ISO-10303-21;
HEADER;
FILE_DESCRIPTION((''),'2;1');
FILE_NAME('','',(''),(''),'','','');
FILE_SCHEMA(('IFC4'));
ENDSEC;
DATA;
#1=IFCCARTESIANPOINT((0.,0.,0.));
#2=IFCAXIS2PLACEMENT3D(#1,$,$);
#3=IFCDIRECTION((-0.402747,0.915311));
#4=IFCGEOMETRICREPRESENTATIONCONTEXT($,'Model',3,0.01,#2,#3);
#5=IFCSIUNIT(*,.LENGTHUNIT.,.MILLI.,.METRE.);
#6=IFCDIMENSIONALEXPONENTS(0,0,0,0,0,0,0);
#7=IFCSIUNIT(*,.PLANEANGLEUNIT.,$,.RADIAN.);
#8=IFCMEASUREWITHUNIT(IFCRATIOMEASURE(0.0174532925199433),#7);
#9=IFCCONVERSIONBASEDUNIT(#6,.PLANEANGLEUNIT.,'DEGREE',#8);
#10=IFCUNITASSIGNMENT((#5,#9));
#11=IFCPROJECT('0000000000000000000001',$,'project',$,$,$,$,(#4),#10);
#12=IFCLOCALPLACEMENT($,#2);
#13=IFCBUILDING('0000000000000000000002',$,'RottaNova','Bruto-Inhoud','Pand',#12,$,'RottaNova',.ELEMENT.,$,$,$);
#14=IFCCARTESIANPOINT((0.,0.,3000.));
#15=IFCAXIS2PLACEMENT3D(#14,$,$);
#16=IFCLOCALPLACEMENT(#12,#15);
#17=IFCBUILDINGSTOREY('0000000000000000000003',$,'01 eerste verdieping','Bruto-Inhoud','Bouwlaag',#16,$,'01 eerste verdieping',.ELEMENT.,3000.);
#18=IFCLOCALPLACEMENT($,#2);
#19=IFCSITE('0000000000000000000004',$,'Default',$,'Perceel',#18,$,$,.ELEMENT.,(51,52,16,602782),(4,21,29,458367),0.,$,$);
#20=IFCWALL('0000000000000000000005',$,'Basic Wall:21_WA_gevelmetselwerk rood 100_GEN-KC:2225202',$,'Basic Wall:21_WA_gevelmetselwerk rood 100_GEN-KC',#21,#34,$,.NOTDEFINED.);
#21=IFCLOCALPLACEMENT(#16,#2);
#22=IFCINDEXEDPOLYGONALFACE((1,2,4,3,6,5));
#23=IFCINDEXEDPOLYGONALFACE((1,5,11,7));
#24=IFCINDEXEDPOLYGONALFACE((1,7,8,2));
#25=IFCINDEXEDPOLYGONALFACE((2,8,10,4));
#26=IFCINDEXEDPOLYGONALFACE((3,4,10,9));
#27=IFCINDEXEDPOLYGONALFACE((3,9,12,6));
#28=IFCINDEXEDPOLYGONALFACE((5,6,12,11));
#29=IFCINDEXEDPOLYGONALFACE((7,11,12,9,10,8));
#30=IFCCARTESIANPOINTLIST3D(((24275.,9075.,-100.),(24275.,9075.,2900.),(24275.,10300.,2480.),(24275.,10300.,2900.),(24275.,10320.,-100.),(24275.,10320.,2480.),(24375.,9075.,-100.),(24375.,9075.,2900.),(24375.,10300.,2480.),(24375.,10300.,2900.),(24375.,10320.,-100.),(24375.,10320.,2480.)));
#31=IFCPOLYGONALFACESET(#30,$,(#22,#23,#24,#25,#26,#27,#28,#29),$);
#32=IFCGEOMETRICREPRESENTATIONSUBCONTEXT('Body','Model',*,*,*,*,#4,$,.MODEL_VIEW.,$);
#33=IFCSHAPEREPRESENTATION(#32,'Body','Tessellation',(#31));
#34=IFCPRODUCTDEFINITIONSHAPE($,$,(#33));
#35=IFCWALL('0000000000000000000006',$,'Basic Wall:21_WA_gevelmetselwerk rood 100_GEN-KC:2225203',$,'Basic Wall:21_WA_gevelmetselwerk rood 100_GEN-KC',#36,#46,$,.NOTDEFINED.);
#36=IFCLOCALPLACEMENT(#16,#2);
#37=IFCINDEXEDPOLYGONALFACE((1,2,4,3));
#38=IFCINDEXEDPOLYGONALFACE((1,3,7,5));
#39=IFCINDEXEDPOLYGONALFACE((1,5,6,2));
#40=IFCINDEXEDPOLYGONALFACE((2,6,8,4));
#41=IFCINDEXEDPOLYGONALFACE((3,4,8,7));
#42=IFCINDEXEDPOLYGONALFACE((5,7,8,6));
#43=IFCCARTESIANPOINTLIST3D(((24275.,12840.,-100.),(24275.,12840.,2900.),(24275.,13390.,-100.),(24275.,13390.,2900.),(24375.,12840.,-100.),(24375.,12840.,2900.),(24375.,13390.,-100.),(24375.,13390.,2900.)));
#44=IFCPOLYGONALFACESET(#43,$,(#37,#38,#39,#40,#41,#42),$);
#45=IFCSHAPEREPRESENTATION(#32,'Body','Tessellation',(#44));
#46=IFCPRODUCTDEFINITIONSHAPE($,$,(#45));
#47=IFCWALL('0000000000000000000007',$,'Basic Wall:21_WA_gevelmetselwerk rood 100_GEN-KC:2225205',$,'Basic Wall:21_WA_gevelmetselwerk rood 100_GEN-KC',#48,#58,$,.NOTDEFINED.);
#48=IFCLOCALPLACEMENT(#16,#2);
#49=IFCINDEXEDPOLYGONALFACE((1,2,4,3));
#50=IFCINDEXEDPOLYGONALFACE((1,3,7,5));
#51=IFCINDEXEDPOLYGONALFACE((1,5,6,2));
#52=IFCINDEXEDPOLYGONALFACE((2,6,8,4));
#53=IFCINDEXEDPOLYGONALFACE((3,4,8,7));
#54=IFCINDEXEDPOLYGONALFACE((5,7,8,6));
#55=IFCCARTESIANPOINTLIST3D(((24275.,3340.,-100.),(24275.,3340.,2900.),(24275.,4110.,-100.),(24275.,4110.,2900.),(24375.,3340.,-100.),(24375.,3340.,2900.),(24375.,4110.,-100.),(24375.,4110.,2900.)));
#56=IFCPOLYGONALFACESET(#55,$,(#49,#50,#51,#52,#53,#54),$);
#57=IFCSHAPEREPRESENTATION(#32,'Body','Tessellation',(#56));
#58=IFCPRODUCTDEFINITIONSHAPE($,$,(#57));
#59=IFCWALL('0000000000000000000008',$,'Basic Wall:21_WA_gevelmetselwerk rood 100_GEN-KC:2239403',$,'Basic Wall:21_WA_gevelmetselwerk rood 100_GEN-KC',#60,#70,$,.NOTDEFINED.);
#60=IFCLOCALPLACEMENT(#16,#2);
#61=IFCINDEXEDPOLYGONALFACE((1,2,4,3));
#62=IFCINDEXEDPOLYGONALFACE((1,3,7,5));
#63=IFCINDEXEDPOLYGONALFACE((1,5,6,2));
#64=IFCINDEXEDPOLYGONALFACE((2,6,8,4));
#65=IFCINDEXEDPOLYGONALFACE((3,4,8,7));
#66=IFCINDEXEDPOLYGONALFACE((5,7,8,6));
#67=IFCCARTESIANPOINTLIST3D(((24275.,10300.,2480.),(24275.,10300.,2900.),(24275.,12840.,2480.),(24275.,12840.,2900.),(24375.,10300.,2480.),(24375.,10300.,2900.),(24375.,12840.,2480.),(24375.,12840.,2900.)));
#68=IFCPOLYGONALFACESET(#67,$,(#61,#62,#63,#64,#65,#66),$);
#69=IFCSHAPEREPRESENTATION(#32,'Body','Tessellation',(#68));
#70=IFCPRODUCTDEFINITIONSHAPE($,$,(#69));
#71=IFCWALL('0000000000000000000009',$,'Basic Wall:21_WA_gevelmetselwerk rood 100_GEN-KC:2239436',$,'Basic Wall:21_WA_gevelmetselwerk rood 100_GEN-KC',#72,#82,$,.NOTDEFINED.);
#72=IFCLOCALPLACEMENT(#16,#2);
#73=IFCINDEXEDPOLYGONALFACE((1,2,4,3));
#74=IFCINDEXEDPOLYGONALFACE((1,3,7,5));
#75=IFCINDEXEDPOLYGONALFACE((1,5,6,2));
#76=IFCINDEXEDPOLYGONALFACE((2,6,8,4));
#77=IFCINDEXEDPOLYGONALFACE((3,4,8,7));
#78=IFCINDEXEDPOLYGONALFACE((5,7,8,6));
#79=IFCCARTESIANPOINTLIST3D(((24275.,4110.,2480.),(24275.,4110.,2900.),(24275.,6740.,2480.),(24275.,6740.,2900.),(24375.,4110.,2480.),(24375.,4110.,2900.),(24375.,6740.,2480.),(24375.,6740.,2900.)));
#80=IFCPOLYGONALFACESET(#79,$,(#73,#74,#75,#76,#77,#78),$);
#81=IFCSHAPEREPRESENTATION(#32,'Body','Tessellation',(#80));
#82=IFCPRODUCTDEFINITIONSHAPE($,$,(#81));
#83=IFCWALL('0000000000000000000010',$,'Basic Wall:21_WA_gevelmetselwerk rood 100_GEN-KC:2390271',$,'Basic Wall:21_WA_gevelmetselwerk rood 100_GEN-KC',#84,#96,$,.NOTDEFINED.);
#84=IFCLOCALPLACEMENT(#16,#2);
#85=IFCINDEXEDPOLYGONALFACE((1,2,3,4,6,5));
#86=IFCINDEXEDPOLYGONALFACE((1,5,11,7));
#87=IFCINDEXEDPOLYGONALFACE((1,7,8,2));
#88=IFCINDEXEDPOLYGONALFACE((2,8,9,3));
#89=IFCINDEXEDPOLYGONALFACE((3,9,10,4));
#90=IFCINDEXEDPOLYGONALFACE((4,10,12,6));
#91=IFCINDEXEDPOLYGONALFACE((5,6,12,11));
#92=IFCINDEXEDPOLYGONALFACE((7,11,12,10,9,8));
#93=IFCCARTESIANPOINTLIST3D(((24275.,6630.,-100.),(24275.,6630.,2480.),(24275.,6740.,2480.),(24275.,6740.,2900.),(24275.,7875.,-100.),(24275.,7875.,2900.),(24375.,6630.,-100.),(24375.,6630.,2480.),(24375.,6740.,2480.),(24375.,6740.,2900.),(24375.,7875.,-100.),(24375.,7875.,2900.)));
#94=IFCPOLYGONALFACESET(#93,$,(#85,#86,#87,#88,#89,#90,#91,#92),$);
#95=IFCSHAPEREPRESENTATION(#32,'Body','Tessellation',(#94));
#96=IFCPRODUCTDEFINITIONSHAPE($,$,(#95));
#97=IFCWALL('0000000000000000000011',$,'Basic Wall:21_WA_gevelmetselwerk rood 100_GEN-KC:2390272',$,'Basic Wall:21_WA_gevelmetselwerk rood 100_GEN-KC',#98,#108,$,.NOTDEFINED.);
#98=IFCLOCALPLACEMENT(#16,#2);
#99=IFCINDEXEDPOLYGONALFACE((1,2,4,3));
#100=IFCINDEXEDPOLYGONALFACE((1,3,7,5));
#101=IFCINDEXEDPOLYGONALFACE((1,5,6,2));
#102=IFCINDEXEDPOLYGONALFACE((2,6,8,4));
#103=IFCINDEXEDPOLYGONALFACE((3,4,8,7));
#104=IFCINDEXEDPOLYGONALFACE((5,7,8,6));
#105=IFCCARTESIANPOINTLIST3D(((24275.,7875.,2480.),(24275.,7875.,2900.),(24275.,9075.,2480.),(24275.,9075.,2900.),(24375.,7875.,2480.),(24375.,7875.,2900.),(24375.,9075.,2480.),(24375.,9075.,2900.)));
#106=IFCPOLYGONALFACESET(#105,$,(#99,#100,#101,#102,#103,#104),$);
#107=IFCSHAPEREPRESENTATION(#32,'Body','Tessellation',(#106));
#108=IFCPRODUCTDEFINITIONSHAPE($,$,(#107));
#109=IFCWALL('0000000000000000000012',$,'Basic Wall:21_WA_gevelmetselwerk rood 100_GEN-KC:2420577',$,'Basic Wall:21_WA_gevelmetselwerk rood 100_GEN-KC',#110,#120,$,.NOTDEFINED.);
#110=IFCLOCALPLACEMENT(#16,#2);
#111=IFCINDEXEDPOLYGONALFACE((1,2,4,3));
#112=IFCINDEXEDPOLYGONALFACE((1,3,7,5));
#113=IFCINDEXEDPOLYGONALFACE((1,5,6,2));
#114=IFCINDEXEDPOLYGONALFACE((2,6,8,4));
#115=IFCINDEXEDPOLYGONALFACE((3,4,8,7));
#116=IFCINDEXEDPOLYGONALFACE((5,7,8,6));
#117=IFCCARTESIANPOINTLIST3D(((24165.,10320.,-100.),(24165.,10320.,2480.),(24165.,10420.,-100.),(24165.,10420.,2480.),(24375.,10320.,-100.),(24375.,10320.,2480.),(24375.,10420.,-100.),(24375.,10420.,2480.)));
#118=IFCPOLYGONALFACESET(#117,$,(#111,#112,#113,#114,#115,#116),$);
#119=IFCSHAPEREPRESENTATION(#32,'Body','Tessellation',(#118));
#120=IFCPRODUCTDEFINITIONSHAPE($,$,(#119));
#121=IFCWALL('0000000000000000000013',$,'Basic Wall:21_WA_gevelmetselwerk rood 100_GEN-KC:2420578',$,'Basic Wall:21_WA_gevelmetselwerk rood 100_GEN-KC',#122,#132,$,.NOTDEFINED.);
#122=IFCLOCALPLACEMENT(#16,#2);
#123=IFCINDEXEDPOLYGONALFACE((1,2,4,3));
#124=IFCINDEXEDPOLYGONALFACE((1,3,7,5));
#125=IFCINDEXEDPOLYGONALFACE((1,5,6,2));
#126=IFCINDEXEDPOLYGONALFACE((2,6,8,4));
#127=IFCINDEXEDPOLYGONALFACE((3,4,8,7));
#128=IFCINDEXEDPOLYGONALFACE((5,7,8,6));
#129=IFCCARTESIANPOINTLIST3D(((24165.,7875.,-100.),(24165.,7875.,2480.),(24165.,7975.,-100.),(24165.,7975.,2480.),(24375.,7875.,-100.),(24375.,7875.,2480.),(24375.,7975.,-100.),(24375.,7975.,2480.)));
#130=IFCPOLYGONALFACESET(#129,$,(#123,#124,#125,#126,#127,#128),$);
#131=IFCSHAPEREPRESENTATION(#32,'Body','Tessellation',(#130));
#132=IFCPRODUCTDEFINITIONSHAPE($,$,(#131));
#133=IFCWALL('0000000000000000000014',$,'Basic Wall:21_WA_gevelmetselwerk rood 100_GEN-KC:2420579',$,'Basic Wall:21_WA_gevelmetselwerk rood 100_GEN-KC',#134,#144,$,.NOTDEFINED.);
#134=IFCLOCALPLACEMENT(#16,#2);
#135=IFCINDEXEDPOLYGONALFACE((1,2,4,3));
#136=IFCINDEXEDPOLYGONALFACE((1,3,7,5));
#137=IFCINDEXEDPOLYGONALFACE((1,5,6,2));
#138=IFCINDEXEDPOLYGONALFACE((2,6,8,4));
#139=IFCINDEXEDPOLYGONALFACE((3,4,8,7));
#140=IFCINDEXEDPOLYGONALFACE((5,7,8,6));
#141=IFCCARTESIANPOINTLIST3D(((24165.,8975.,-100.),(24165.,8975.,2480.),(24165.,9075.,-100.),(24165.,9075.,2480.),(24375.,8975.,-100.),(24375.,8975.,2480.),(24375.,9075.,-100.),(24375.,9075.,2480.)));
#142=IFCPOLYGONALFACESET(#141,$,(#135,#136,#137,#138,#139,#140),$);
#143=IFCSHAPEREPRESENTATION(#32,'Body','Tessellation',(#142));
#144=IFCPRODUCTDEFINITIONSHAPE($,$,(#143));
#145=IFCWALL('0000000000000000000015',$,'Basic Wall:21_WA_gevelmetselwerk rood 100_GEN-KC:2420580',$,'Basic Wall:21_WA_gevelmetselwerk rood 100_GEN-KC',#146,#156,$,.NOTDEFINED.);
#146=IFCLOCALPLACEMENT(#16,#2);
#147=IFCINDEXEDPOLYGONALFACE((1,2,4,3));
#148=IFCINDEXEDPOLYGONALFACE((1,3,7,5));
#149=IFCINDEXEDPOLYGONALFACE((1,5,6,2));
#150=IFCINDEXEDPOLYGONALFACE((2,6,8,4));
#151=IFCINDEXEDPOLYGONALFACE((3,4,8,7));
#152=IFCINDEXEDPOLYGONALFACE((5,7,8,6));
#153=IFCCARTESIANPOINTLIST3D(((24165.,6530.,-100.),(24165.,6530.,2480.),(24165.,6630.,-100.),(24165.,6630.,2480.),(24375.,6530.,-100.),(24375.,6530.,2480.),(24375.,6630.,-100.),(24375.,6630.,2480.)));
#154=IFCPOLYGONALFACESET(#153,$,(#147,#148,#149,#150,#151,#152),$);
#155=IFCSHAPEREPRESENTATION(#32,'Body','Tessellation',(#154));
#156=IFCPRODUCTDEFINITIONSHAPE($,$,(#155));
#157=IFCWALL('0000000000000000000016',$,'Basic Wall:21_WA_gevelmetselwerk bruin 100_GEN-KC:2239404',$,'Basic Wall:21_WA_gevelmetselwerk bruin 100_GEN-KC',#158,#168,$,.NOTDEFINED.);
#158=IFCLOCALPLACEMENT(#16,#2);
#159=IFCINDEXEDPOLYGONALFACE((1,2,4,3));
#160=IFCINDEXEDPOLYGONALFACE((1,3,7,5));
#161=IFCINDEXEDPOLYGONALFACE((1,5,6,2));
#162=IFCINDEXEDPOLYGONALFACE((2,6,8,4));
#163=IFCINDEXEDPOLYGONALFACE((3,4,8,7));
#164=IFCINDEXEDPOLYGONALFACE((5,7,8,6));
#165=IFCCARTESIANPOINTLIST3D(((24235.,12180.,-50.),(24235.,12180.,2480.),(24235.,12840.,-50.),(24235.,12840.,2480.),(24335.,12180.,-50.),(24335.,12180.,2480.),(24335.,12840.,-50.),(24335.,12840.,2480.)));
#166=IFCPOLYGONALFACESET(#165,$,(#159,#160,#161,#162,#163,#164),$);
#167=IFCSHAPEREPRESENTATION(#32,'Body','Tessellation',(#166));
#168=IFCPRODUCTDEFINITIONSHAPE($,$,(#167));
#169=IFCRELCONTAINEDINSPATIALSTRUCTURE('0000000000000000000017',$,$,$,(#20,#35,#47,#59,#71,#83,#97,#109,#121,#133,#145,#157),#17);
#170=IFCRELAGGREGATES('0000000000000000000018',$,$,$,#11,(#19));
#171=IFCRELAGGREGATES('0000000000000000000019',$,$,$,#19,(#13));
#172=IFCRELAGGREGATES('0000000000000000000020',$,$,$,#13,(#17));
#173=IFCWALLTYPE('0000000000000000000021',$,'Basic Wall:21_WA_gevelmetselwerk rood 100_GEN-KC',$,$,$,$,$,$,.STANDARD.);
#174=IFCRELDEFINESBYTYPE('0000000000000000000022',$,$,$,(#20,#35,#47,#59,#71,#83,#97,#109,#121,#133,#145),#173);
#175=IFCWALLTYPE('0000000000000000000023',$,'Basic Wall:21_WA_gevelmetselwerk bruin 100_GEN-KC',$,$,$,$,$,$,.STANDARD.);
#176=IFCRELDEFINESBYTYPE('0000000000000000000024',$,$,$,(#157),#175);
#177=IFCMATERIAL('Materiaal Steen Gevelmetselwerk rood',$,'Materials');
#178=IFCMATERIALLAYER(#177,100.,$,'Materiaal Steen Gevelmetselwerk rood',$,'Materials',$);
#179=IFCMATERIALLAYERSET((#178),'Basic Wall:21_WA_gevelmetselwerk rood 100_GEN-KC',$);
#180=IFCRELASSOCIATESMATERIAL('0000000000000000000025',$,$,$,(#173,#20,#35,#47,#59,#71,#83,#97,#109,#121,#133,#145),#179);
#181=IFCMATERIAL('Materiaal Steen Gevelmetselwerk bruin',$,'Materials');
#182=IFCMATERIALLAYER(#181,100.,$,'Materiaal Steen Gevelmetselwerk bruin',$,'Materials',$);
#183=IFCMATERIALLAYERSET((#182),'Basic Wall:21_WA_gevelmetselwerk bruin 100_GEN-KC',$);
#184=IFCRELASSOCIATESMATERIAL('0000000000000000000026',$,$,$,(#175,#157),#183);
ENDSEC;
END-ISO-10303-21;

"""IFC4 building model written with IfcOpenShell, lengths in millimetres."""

from ifc_helpers import new_model, entity, si_unit, converted_unit, direction, frame, frame_2d, origin, place, context, subcontext, project, spatial, polyline, rectangle, extrude, clip, bounded_halfspace, material, layer, layer_set, type_object, element, save


model = new_model("IFC4")

# Units and contexts
model_context = context("Model", 3, precision=0.01, world=origin(), true_north=direction((-0.402747, 0.915311)))
body_context = subcontext(model_context, "Body", "Model", "MODEL_VIEW")
ifc_project = project(units=[si_unit("LENGTHUNIT", "METRE", prefix="MILLI"), converted_unit("PLANEANGLEUNIT", "DEGREE", entity("IfcRatioMeasure", 0.0174532925199433), si_unit("PLANEANGLEUNIT", "RADIAN"), dimensions=[0, 0, 0, 0, 0, 0, 0])], contexts=[model_context])

# Site, building, storey
site_placement = place(None, origin())
site = spatial("IfcSite", under=ifc_project, at=site_placement, Name="Default", ObjectType="Perceel", CompositionType="ELEMENT", RefLatitude=(51, 52, 16, 602782), RefLongitude=(4, 21, 29, 458367), RefElevation=0.0)
building_placement = place(None, origin())
building = spatial("IfcBuilding", under=site, at=building_placement, Name="RottaNova", Description="Bruto-Inhoud", ObjectType="Pand", LongName="RottaNova", CompositionType="ELEMENT")
storey_placement = place(building_placement, frame((0.0, 0.0, 3000.0)))
storey = spatial("IfcBuildingStorey", under=building, at=storey_placement, Name="01 eerste verdieping", Description="Bruto-Inhoud", ObjectType="Bouwlaag", LongName="01 eerste verdieping", CompositionType="ELEMENT", Elevation=3000.0)

# Walls
ifc_material_1 = material(Name="Materiaal Steen Gevelmetselwerk rood", Category="Materials")
ifc_layer_1 = layer(ifc_material_1, 100.0, Name="Materiaal Steen Gevelmetselwerk rood", Category="Materials")
ifc_layer_set_1 = layer_set([ifc_layer_1], Name="Basic Wall:21_WA_gevelmetselwerk rood 100_GEN-KC")
wall_type_1 = type_object("IfcWallType", Name="Basic Wall:21_WA_gevelmetselwerk rood 100_GEN-KC", PredefinedType="STANDARD", material=ifc_layer_set_1)
wall_1_placement = place(storey_placement, frame((24325.0, 9075.0, -100.0), z_axis=(0.0, 0.0, 1.0), x_axis=(0.0, 1.0, 0.0)))
element("IfcWall", 1, at=wall_1_placement, inside=storey, type_object=wall_type_1, material=ifc_layer_set_1, Name="Basic Wall:21_WA_gevelmetselwerk rood 100_GEN-KC:2225202", ObjectType="Basic Wall:21_WA_gevelmetselwerk rood 100_GEN-KC", PredefinedType="NOTDEFINED", context=body_context, shape_type="Clipping", body=[
    clip(clip(extrude(rectangle(XDim=1245.0, YDim=100.0, at=frame_2d((622.5, 0.0), x_axis=(-1.0, 0.0))), origin(), (0.0, 0.0, 1.0), 3000.0), bounded_halfspace(frame((1225.0, 50.0, 2580.0), z_axis=(0.0, 0.0, -1.0), x_axis=(0.0, -1.0, 0.0)), True, frame((1225.0, 50.0, 2580.0), z_axis=(0.0, 0.0, -1.0), x_axis=(0.0, -1.0, 0.0)), polyline([(0.0, 0.0), (0.0, -20.0), (100.0, -20.0), (100.0, 0.0), (0.0, 0.0)]))), bounded_halfspace(frame((1225.0, -50.0, 2580.0), z_axis=(-1.0, 0.0, 0.0), x_axis=(0.0, -1.0, 0.0)), True, frame((1225.0, -50.0, 2580.0), z_axis=(-1.0, 0.0, 0.0), x_axis=(0.0, -1.0, 0.0)), polyline([(0.0, 0.0), (0.0, 128016.0), (-30480.0, 128016.0), (-30480.0, 0.0), (0.0, 0.0)]))),
])
wall_2_placement = place(storey_placement, frame((24325.0, 12840.0, -100.0), z_axis=(0.0, 0.0, 1.0), x_axis=(0.0, 1.0, 0.0)))
element("IfcWall", 2, at=wall_2_placement, inside=storey, type_object=wall_type_1, material=ifc_layer_set_1, Name="Basic Wall:21_WA_gevelmetselwerk rood 100_GEN-KC:2225203", ObjectType="Basic Wall:21_WA_gevelmetselwerk rood 100_GEN-KC", PredefinedType="NOTDEFINED", context=body_context, shape_type="SweptSolid", body=[
    extrude(rectangle(XDim=550.0, YDim=100.0, at=frame_2d((275.0, 0.0), x_axis=(-1.0, 0.0))), origin(), (0.0, 0.0, 1.0), 3000.0),
])
wall_3_placement = place(storey_placement, frame((24325.0, 3340.0, -100.0), z_axis=(0.0, 0.0, 1.0), x_axis=(0.0, 1.0, 0.0)))
element("IfcWall", 3, at=wall_3_placement, inside=storey, type_object=wall_type_1, material=ifc_layer_set_1, Name="Basic Wall:21_WA_gevelmetselwerk rood 100_GEN-KC:2225205", ObjectType="Basic Wall:21_WA_gevelmetselwerk rood 100_GEN-KC", PredefinedType="NOTDEFINED", context=body_context, shape_type="SweptSolid", body=[
    extrude(rectangle(XDim=770.0, YDim=100.0, at=frame_2d((385.0, 0.0), x_axis=(-1.0, 0.0))), origin(), (0.0, 0.0, 1.0), 3000.0),
])
wall_4_placement = place(storey_placement, frame((24325.0, 12840.0, 2480.0), z_axis=(0.0, 0.0, 1.0), x_axis=(0.0, -1.0, 0.0)))
element("IfcWall", 4, at=wall_4_placement, inside=storey, type_object=wall_type_1, material=ifc_layer_set_1, Name="Basic Wall:21_WA_gevelmetselwerk rood 100_GEN-KC:2239403", ObjectType="Basic Wall:21_WA_gevelmetselwerk rood 100_GEN-KC", PredefinedType="NOTDEFINED", context=body_context, shape_type="SweptSolid", body=[
    extrude(rectangle(XDim=2540.0, YDim=100.0, at=frame_2d((1270.0, 0.0), x_axis=(-1.0, 0.0))), origin(), (0.0, 0.0, 1.0), 420.0),
])
wall_5_placement = place(storey_placement, frame((24325.0, 4110.0, 2480.0), z_axis=(0.0, 0.0, 1.0), x_axis=(0.0, 1.0, 0.0)))
element("IfcWall", 5, at=wall_5_placement, inside=storey, type_object=wall_type_1, material=ifc_layer_set_1, Name="Basic Wall:21_WA_gevelmetselwerk rood 100_GEN-KC:2239436", ObjectType="Basic Wall:21_WA_gevelmetselwerk rood 100_GEN-KC", PredefinedType="NOTDEFINED", context=body_context, shape_type="SweptSolid", body=[
    extrude(rectangle(XDim=2630.0, YDim=100.0, at=frame_2d((1315.0, 0.0), x_axis=(-1.0, 0.0))), origin(), (0.0, 0.0, 1.0), 420.0),
])
wall_6_placement = place(storey_placement, frame((24325.0, 6630.0, -100.0), z_axis=(0.0, 0.0, 1.0), x_axis=(0.0, 1.0, 0.0)))
element("IfcWall", 6, at=wall_6_placement, inside=storey, type_object=wall_type_1, material=ifc_layer_set_1, Name="Basic Wall:21_WA_gevelmetselwerk rood 100_GEN-KC:2390271", ObjectType="Basic Wall:21_WA_gevelmetselwerk rood 100_GEN-KC", PredefinedType="NOTDEFINED", context=body_context, shape_type="Clipping", body=[
    clip(clip(extrude(rectangle(XDim=1245.0, YDim=100.0, at=frame_2d((622.5, 0.0), x_axis=(-1.0, 0.0))), origin(), (0.0, 0.0, 1.0), 3000.0), bounded_halfspace(frame((110.0, -50.0, 2580.0), z_axis=(0.0, 0.0, -1.0), x_axis=(0.0, 1.0, 0.0)), True, frame((110.0, -50.0, 2580.0), z_axis=(0.0, 0.0, -1.0), x_axis=(0.0, 1.0, 0.0)), polyline([(0.0, 0.0), (0.0, -110.0), (100.0, -110.0), (100.0, 0.0), (0.0, 0.0)]))), bounded_halfspace(frame((110.0, 50.0, 2580.0), z_axis=(1.0, 0.0, 0.0), x_axis=(0.0, 1.0, 0.0)), True, frame((110.0, 50.0, 2580.0), z_axis=(1.0, 0.0, 0.0), x_axis=(0.0, 1.0, 0.0)), polyline([(0.0, 0.0), (0.0, 128016.0), (-30480.0, 128016.0), (-30480.0, 0.0), (0.0, 0.0)]))),
])
wall_7_placement = place(storey_placement, frame((24325.0, 7875.0, 2480.0), z_axis=(0.0, 0.0, 1.0), x_axis=(0.0, 1.0, 0.0)))
element("IfcWall", 7, at=wall_7_placement, inside=storey, type_object=wall_type_1, material=ifc_layer_set_1, Name="Basic Wall:21_WA_gevelmetselwerk rood 100_GEN-KC:2390272", ObjectType="Basic Wall:21_WA_gevelmetselwerk rood 100_GEN-KC", PredefinedType="NOTDEFINED", context=body_context, shape_type="SweptSolid", body=[
    extrude(rectangle(XDim=1200.0, YDim=100.0, at=frame_2d((600.0, 0.0), x_axis=(-1.0, 0.0))), origin(), (0.0, 0.0, 1.0), 420.0),
])
wall_8_placement = place(storey_placement, frame((24375.0, 10370.0, -100.0), z_axis=(0.0, 0.0, 1.0), x_axis=(-1.0, 0.0, 0.0)))
element("IfcWall", 8, at=wall_8_placement, inside=storey, type_object=wall_type_1, material=ifc_layer_set_1, Name="Basic Wall:21_WA_gevelmetselwerk rood 100_GEN-KC:2420577", ObjectType="Basic Wall:21_WA_gevelmetselwerk rood 100_GEN-KC", PredefinedType="NOTDEFINED", context=body_context, shape_type="SweptSolid", body=[
    extrude(rectangle(XDim=210.0, YDim=100.0, at=frame_2d((105.0, 0.0), x_axis=(-1.0, 0.0))), origin(), (0.0, 0.0, 1.0), 2580.0),
])
wall_9_placement = place(storey_placement, frame((24375.0, 7925.0, -100.0), z_axis=(0.0, 0.0, 1.0), x_axis=(-1.0, 0.0, 0.0)))
element("IfcWall", 9, at=wall_9_placement, inside=storey, type_object=wall_type_1, material=ifc_layer_set_1, Name="Basic Wall:21_WA_gevelmetselwerk rood 100_GEN-KC:2420578", ObjectType="Basic Wall:21_WA_gevelmetselwerk rood 100_GEN-KC", PredefinedType="NOTDEFINED", context=body_context, shape_type="SweptSolid", body=[
    extrude(rectangle(XDim=210.0, YDim=100.0, at=frame_2d((105.0, 0.0), x_axis=(-1.0, 0.0))), origin(), (0.0, 0.0, 1.0), 2580.0),
])
wall_10_placement = place(storey_placement, frame((24375.0, 9025.0, -100.0), z_axis=(0.0, 0.0, 1.0), x_axis=(-1.0, 0.0, 0.0)))
element("IfcWall", 10, at=wall_10_placement, inside=storey, type_object=wall_type_1, material=ifc_layer_set_1, Name="Basic Wall:21_WA_gevelmetselwerk rood 100_GEN-KC:2420579", ObjectType="Basic Wall:21_WA_gevelmetselwerk rood 100_GEN-KC", PredefinedType="NOTDEFINED", context=body_context, shape_type="SweptSolid", body=[
    extrude(rectangle(XDim=210.0, YDim=100.0, at=frame_2d((105.0, 0.0), x_axis=(-1.0, 0.0))), origin(), (0.0, 0.0, 1.0), 2580.0),
])
wall_11_placement = place(storey_placement, frame((24375.0, 6580.0, -100.0), z_axis=(0.0, 0.0, 1.0), x_axis=(-1.0, 0.0, 0.0)))
element("IfcWall", 11, at=wall_11_placement, inside=storey, type_object=wall_type_1, material=ifc_layer_set_1, Name="Basic Wall:21_WA_gevelmetselwerk rood 100_GEN-KC:2420580", ObjectType="Basic Wall:21_WA_gevelmetselwerk rood 100_GEN-KC", PredefinedType="NOTDEFINED", context=body_context, shape_type="SweptSolid", body=[
    extrude(rectangle(XDim=210.0, YDim=100.0, at=frame_2d((105.0, 0.0), x_axis=(-1.0, 0.0))), origin(), (0.0, 0.0, 1.0), 2580.0),
])
ifc_material_2 = material(Name="Materiaal Steen Gevelmetselwerk bruin", Category="Materials")
ifc_layer_2 = layer(ifc_material_2, 100.0, Name="Materiaal Steen Gevelmetselwerk bruin", Category="Materials")
ifc_layer_set_2 = layer_set([ifc_layer_2], Name="Basic Wall:21_WA_gevelmetselwerk bruin 100_GEN-KC")
wall_type_2 = type_object("IfcWallType", Name="Basic Wall:21_WA_gevelmetselwerk bruin 100_GEN-KC", PredefinedType="STANDARD", material=ifc_layer_set_2)
wall_12_placement = place(storey_placement, frame((24285.0, 12840.0, -50.0), z_axis=(0.0, 0.0, 1.0), x_axis=(0.0, -1.0, 0.0)))
element("IfcWall", 12, at=wall_12_placement, inside=storey, type_object=wall_type_2, material=ifc_layer_set_2, Name="Basic Wall:21_WA_gevelmetselwerk bruin 100_GEN-KC:2239404", ObjectType="Basic Wall:21_WA_gevelmetselwerk bruin 100_GEN-KC", PredefinedType="NOTDEFINED", context=body_context, shape_type="SweptSolid", body=[
    extrude(rectangle(XDim=660.0, YDim=100.0, at=frame_2d((330.0, 0.0), x_axis=(-1.0, 0.0))), origin(), (0.0, 0.0, 1.0), 2530.0),
])

save(model, "model.ifc")
